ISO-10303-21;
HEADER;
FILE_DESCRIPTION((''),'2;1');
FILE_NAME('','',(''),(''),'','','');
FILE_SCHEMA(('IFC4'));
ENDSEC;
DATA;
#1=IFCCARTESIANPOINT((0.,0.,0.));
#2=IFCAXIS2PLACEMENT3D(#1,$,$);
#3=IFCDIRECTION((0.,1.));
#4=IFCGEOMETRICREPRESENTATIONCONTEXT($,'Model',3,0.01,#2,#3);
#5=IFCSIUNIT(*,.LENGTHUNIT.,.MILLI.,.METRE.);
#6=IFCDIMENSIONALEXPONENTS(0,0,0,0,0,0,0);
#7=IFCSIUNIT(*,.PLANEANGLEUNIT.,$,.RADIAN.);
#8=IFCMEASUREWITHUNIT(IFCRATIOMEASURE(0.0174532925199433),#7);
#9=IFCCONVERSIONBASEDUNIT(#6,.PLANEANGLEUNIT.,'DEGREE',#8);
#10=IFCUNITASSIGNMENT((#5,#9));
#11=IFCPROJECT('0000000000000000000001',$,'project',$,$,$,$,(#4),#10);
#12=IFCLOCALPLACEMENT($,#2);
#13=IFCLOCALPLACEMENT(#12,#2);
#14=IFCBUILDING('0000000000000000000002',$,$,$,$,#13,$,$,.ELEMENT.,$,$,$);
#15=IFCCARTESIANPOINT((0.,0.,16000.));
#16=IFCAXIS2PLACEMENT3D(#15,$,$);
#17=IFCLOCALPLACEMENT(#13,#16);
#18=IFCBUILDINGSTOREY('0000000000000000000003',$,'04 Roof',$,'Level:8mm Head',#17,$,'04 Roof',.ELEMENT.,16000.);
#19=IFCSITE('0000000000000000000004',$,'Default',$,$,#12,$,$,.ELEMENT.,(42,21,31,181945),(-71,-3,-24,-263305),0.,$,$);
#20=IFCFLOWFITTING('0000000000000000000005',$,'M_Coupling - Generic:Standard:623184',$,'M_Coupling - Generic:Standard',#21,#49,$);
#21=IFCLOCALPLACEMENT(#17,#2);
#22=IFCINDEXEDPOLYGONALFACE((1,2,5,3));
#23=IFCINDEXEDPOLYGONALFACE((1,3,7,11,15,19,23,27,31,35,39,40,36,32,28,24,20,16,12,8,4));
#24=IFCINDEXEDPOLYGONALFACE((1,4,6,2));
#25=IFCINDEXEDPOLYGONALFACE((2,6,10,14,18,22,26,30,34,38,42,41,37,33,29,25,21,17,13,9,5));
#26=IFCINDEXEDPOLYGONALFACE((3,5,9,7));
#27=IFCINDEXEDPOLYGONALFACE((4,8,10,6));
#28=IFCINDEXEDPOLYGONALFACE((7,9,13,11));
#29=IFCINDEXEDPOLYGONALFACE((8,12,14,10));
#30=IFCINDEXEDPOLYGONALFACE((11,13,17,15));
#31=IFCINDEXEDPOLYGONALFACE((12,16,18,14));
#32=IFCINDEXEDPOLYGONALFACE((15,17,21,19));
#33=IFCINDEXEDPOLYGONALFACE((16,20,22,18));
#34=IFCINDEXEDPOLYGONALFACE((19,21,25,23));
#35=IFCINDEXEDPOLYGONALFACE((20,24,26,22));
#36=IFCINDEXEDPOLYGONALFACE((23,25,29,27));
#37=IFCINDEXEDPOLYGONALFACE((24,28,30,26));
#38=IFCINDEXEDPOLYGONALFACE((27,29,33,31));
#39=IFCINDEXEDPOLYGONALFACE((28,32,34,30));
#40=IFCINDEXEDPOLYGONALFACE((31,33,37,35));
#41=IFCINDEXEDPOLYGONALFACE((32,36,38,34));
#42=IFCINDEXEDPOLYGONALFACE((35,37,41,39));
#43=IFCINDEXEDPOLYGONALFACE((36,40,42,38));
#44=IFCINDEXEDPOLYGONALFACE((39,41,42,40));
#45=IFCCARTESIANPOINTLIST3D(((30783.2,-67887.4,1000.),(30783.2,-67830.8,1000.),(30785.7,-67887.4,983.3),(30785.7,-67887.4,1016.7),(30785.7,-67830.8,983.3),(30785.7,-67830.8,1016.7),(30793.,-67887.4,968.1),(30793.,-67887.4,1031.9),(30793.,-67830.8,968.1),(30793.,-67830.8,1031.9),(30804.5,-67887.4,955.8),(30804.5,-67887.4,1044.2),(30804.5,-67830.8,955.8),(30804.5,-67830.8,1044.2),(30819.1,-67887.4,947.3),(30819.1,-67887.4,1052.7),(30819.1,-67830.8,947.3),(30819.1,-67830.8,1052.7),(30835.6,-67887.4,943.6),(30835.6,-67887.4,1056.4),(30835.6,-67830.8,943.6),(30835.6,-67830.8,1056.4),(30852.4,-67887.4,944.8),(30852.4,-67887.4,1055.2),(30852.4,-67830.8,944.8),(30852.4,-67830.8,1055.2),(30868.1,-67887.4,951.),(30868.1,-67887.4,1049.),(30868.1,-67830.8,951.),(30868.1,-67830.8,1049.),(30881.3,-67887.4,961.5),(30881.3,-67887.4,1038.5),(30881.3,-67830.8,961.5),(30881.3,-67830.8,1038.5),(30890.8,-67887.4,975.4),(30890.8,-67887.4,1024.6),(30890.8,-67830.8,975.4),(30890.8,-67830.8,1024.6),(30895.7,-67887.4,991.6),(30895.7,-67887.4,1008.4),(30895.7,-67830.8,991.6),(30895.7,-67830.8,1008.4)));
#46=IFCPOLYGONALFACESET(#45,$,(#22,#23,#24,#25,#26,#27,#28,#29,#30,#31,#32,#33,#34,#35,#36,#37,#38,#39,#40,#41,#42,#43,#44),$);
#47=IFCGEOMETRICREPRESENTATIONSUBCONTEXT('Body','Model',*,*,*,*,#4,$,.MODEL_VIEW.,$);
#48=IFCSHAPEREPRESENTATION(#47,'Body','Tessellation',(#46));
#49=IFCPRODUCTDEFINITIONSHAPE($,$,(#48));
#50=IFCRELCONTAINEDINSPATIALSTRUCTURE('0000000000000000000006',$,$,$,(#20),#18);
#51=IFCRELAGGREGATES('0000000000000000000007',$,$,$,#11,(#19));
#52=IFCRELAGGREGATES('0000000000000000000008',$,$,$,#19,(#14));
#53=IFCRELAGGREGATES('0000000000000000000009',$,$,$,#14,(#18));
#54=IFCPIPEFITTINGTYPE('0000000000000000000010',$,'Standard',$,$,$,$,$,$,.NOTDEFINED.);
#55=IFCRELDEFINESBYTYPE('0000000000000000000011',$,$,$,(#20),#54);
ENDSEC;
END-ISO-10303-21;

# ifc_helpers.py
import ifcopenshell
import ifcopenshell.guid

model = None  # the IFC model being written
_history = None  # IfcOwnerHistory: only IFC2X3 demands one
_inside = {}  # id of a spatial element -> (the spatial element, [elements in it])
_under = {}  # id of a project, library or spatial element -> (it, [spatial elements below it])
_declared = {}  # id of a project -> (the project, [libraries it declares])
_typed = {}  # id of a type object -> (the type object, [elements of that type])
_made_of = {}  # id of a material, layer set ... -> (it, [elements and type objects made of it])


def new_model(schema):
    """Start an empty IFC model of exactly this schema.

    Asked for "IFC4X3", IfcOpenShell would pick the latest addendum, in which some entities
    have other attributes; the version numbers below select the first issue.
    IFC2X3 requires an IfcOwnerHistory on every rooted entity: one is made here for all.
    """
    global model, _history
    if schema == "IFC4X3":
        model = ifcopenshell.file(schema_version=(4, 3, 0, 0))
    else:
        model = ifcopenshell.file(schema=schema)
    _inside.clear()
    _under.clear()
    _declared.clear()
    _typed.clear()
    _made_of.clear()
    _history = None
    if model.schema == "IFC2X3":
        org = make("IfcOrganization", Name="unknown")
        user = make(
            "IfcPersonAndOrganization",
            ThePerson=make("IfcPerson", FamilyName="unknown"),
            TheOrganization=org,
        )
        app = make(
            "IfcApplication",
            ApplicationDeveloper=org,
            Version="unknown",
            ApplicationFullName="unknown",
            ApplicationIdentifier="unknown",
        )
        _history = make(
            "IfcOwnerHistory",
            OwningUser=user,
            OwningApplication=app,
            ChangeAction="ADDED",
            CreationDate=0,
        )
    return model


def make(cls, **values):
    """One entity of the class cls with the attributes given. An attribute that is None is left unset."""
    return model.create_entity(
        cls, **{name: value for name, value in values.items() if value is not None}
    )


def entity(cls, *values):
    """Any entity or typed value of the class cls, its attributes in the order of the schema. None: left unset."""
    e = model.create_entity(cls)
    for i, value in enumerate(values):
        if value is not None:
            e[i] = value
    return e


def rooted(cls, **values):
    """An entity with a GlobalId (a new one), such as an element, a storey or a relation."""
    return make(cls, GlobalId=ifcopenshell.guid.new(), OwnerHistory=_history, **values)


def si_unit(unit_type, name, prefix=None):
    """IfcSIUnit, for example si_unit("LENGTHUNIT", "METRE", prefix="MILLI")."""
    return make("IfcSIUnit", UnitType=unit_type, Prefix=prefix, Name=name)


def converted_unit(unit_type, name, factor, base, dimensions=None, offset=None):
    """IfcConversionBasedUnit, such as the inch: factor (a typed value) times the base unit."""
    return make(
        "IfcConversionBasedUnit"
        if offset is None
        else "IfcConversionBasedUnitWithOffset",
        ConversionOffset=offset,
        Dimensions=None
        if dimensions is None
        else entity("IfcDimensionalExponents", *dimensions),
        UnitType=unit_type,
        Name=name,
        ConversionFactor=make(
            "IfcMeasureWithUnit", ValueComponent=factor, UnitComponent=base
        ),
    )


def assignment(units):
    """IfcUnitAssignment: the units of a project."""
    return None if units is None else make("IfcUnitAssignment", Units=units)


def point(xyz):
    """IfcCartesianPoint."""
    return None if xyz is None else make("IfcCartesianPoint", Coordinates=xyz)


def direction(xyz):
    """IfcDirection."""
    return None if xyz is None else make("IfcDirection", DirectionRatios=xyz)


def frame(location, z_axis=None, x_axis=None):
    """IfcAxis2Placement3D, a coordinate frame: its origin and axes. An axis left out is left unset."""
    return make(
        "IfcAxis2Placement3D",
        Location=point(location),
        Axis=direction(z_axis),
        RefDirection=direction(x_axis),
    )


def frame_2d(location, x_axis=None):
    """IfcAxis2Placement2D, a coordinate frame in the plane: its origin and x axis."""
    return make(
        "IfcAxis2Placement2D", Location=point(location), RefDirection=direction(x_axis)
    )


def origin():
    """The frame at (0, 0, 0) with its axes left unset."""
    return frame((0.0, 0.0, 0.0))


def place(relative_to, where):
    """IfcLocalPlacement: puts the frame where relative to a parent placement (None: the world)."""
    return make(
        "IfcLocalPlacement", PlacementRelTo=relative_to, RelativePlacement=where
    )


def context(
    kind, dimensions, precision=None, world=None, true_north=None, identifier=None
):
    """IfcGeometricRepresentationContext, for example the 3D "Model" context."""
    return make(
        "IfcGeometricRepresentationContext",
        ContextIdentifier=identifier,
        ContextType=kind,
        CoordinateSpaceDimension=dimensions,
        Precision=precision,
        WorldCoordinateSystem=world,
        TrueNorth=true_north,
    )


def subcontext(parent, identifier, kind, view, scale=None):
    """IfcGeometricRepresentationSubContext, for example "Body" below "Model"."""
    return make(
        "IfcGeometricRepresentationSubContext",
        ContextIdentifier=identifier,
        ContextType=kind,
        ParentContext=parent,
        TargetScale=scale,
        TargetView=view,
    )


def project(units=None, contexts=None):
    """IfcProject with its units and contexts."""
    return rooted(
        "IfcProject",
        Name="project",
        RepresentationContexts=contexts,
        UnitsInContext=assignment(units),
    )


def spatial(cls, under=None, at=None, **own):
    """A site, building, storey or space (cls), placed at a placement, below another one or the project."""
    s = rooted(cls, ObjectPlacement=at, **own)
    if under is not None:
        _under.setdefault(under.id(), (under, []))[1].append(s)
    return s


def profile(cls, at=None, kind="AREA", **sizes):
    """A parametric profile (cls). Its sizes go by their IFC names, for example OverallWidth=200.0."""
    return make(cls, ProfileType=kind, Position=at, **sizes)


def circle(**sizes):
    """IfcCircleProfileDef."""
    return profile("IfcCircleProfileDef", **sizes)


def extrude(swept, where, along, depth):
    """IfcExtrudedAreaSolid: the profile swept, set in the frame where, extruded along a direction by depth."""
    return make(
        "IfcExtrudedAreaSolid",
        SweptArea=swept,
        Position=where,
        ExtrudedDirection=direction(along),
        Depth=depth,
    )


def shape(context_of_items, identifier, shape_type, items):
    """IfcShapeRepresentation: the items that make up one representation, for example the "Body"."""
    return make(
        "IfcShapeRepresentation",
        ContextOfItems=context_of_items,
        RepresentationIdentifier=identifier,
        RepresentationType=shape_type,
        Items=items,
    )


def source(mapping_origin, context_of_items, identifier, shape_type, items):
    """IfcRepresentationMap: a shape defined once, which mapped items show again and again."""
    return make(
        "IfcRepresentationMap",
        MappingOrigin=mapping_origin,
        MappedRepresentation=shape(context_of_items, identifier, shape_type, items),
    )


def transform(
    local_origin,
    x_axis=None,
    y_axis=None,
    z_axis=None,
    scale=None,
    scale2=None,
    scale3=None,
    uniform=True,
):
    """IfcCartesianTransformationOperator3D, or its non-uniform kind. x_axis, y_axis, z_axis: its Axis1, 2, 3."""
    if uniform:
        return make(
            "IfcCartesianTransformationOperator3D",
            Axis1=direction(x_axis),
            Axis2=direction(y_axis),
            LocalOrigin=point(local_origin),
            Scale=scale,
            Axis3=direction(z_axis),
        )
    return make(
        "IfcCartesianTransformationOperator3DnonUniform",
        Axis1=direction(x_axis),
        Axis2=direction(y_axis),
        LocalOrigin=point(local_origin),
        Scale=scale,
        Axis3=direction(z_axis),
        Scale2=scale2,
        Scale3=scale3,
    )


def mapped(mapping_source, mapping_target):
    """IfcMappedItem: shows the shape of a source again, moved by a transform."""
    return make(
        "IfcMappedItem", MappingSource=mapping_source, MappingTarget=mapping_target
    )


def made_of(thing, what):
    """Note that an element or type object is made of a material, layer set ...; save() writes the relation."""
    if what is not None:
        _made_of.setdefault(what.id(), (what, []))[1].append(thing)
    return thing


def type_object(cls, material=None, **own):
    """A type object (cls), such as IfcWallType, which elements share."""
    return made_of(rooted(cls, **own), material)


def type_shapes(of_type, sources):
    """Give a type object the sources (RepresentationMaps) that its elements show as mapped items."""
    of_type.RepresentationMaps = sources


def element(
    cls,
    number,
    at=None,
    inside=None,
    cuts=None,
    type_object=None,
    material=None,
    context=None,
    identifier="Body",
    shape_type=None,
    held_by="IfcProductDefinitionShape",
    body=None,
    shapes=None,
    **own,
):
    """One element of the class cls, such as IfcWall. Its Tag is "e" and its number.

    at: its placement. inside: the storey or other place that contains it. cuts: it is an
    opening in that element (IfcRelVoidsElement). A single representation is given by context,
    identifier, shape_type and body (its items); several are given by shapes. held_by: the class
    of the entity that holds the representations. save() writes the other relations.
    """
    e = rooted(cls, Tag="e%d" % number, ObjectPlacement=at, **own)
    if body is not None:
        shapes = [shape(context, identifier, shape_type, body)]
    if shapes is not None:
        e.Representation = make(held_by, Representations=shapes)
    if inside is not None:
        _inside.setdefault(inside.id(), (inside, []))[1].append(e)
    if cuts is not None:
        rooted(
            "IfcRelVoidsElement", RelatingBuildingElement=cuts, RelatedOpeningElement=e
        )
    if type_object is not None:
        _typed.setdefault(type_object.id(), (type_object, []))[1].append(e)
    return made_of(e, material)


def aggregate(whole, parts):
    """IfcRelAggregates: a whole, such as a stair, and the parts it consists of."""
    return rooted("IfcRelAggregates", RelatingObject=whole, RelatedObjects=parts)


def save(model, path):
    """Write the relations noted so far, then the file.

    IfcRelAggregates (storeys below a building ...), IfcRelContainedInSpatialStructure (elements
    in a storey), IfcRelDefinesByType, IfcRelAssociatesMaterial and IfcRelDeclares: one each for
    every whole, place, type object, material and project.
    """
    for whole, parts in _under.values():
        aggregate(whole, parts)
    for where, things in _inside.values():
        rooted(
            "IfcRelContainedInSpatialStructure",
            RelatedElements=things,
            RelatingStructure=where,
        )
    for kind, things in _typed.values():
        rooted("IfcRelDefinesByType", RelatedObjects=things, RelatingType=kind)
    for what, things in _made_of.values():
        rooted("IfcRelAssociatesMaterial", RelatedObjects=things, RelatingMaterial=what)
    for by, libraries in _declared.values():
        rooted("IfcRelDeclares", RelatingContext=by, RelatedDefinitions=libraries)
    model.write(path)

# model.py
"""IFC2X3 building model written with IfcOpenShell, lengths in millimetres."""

from ifc_helpers import new_model, entity, si_unit, converted_unit, direction, frame, frame_2d, origin, place, context, subcontext, project, spatial, circle, extrude, source, transform, mapped, type_object, type_shapes, element, save


model = new_model("IFC2X3")

# Units and contexts
model_context = context("Model", 3, precision=0.01, world=origin(), true_north=direction((0.0, 1.0)))
body_context = subcontext(model_context, "Body", "Model", "MODEL_VIEW")
ifc_project = project(units=[si_unit("LENGTHUNIT", "METRE", prefix="MILLI"), converted_unit("PLANEANGLEUNIT", "DEGREE", entity("IfcRatioMeasure", 0.0174532925199433), si_unit("PLANEANGLEUNIT", "RADIAN"), dimensions=[0, 0, 0, 0, 0, 0, 0])], contexts=[model_context])

# Site, building, storey
site_placement = place(None, origin())
site = spatial("IfcSite", under=ifc_project, at=site_placement, Name="Default", CompositionType="ELEMENT", RefLatitude=(42, 21, 31, 181945), RefLongitude=(-71, -3, -24, -263305), RefElevation=0.0)
building_placement = place(site_placement, origin())
building = spatial("IfcBuilding", under=site, at=building_placement, CompositionType="ELEMENT")
storey_placement = place(building_placement, frame((0.0, 0.0, 16000.0)))
storey = spatial("IfcBuildingStorey", under=building, at=storey_placement, Name="04 Roof", ObjectType="Level:8mm Head", LongName="04 Roof", CompositionType="ELEMENT", Elevation=16000.0)

# Flow fitting
pipe_fitting_type = type_object("IfcPipeFittingType", Name="Standard", PredefinedType="NOTDEFINED")
shared_shape = source(origin(), body_context, "Body", "SweptSolid", [
    extrude(circle(Radius=56.6, at=frame_2d((0.0, 0.0), x_axis=(1.0, 0.0))), frame((-28.3, 0.0, 0.0), z_axis=(1.0, 0.0, 0.0), x_axis=(0.0, 1.0, 0.0)), (0.0, 0.0, 1.0), 56.6),
])
type_shapes(pipe_fitting_type, [shared_shape])
flow_fitting_placement = place(storey_placement, frame((30839.8, -67859.1, 1000.0), z_axis=(0.0, 0.0, 1.0), x_axis=(0.0, 1.0, 0.0)))
element("IfcFlowFitting", 1, at=flow_fitting_placement, inside=storey, type_object=pipe_fitting_type, Name="M_Coupling - Generic:Standard:623184", ObjectType="M_Coupling - Generic:Standard", context=body_context, shape_type="MappedRepresentation", body=[
    mapped(shared_shape, transform((0.0, 0.0, 0.0), scale=1.0)),
])

save(model, "model.ifc")
